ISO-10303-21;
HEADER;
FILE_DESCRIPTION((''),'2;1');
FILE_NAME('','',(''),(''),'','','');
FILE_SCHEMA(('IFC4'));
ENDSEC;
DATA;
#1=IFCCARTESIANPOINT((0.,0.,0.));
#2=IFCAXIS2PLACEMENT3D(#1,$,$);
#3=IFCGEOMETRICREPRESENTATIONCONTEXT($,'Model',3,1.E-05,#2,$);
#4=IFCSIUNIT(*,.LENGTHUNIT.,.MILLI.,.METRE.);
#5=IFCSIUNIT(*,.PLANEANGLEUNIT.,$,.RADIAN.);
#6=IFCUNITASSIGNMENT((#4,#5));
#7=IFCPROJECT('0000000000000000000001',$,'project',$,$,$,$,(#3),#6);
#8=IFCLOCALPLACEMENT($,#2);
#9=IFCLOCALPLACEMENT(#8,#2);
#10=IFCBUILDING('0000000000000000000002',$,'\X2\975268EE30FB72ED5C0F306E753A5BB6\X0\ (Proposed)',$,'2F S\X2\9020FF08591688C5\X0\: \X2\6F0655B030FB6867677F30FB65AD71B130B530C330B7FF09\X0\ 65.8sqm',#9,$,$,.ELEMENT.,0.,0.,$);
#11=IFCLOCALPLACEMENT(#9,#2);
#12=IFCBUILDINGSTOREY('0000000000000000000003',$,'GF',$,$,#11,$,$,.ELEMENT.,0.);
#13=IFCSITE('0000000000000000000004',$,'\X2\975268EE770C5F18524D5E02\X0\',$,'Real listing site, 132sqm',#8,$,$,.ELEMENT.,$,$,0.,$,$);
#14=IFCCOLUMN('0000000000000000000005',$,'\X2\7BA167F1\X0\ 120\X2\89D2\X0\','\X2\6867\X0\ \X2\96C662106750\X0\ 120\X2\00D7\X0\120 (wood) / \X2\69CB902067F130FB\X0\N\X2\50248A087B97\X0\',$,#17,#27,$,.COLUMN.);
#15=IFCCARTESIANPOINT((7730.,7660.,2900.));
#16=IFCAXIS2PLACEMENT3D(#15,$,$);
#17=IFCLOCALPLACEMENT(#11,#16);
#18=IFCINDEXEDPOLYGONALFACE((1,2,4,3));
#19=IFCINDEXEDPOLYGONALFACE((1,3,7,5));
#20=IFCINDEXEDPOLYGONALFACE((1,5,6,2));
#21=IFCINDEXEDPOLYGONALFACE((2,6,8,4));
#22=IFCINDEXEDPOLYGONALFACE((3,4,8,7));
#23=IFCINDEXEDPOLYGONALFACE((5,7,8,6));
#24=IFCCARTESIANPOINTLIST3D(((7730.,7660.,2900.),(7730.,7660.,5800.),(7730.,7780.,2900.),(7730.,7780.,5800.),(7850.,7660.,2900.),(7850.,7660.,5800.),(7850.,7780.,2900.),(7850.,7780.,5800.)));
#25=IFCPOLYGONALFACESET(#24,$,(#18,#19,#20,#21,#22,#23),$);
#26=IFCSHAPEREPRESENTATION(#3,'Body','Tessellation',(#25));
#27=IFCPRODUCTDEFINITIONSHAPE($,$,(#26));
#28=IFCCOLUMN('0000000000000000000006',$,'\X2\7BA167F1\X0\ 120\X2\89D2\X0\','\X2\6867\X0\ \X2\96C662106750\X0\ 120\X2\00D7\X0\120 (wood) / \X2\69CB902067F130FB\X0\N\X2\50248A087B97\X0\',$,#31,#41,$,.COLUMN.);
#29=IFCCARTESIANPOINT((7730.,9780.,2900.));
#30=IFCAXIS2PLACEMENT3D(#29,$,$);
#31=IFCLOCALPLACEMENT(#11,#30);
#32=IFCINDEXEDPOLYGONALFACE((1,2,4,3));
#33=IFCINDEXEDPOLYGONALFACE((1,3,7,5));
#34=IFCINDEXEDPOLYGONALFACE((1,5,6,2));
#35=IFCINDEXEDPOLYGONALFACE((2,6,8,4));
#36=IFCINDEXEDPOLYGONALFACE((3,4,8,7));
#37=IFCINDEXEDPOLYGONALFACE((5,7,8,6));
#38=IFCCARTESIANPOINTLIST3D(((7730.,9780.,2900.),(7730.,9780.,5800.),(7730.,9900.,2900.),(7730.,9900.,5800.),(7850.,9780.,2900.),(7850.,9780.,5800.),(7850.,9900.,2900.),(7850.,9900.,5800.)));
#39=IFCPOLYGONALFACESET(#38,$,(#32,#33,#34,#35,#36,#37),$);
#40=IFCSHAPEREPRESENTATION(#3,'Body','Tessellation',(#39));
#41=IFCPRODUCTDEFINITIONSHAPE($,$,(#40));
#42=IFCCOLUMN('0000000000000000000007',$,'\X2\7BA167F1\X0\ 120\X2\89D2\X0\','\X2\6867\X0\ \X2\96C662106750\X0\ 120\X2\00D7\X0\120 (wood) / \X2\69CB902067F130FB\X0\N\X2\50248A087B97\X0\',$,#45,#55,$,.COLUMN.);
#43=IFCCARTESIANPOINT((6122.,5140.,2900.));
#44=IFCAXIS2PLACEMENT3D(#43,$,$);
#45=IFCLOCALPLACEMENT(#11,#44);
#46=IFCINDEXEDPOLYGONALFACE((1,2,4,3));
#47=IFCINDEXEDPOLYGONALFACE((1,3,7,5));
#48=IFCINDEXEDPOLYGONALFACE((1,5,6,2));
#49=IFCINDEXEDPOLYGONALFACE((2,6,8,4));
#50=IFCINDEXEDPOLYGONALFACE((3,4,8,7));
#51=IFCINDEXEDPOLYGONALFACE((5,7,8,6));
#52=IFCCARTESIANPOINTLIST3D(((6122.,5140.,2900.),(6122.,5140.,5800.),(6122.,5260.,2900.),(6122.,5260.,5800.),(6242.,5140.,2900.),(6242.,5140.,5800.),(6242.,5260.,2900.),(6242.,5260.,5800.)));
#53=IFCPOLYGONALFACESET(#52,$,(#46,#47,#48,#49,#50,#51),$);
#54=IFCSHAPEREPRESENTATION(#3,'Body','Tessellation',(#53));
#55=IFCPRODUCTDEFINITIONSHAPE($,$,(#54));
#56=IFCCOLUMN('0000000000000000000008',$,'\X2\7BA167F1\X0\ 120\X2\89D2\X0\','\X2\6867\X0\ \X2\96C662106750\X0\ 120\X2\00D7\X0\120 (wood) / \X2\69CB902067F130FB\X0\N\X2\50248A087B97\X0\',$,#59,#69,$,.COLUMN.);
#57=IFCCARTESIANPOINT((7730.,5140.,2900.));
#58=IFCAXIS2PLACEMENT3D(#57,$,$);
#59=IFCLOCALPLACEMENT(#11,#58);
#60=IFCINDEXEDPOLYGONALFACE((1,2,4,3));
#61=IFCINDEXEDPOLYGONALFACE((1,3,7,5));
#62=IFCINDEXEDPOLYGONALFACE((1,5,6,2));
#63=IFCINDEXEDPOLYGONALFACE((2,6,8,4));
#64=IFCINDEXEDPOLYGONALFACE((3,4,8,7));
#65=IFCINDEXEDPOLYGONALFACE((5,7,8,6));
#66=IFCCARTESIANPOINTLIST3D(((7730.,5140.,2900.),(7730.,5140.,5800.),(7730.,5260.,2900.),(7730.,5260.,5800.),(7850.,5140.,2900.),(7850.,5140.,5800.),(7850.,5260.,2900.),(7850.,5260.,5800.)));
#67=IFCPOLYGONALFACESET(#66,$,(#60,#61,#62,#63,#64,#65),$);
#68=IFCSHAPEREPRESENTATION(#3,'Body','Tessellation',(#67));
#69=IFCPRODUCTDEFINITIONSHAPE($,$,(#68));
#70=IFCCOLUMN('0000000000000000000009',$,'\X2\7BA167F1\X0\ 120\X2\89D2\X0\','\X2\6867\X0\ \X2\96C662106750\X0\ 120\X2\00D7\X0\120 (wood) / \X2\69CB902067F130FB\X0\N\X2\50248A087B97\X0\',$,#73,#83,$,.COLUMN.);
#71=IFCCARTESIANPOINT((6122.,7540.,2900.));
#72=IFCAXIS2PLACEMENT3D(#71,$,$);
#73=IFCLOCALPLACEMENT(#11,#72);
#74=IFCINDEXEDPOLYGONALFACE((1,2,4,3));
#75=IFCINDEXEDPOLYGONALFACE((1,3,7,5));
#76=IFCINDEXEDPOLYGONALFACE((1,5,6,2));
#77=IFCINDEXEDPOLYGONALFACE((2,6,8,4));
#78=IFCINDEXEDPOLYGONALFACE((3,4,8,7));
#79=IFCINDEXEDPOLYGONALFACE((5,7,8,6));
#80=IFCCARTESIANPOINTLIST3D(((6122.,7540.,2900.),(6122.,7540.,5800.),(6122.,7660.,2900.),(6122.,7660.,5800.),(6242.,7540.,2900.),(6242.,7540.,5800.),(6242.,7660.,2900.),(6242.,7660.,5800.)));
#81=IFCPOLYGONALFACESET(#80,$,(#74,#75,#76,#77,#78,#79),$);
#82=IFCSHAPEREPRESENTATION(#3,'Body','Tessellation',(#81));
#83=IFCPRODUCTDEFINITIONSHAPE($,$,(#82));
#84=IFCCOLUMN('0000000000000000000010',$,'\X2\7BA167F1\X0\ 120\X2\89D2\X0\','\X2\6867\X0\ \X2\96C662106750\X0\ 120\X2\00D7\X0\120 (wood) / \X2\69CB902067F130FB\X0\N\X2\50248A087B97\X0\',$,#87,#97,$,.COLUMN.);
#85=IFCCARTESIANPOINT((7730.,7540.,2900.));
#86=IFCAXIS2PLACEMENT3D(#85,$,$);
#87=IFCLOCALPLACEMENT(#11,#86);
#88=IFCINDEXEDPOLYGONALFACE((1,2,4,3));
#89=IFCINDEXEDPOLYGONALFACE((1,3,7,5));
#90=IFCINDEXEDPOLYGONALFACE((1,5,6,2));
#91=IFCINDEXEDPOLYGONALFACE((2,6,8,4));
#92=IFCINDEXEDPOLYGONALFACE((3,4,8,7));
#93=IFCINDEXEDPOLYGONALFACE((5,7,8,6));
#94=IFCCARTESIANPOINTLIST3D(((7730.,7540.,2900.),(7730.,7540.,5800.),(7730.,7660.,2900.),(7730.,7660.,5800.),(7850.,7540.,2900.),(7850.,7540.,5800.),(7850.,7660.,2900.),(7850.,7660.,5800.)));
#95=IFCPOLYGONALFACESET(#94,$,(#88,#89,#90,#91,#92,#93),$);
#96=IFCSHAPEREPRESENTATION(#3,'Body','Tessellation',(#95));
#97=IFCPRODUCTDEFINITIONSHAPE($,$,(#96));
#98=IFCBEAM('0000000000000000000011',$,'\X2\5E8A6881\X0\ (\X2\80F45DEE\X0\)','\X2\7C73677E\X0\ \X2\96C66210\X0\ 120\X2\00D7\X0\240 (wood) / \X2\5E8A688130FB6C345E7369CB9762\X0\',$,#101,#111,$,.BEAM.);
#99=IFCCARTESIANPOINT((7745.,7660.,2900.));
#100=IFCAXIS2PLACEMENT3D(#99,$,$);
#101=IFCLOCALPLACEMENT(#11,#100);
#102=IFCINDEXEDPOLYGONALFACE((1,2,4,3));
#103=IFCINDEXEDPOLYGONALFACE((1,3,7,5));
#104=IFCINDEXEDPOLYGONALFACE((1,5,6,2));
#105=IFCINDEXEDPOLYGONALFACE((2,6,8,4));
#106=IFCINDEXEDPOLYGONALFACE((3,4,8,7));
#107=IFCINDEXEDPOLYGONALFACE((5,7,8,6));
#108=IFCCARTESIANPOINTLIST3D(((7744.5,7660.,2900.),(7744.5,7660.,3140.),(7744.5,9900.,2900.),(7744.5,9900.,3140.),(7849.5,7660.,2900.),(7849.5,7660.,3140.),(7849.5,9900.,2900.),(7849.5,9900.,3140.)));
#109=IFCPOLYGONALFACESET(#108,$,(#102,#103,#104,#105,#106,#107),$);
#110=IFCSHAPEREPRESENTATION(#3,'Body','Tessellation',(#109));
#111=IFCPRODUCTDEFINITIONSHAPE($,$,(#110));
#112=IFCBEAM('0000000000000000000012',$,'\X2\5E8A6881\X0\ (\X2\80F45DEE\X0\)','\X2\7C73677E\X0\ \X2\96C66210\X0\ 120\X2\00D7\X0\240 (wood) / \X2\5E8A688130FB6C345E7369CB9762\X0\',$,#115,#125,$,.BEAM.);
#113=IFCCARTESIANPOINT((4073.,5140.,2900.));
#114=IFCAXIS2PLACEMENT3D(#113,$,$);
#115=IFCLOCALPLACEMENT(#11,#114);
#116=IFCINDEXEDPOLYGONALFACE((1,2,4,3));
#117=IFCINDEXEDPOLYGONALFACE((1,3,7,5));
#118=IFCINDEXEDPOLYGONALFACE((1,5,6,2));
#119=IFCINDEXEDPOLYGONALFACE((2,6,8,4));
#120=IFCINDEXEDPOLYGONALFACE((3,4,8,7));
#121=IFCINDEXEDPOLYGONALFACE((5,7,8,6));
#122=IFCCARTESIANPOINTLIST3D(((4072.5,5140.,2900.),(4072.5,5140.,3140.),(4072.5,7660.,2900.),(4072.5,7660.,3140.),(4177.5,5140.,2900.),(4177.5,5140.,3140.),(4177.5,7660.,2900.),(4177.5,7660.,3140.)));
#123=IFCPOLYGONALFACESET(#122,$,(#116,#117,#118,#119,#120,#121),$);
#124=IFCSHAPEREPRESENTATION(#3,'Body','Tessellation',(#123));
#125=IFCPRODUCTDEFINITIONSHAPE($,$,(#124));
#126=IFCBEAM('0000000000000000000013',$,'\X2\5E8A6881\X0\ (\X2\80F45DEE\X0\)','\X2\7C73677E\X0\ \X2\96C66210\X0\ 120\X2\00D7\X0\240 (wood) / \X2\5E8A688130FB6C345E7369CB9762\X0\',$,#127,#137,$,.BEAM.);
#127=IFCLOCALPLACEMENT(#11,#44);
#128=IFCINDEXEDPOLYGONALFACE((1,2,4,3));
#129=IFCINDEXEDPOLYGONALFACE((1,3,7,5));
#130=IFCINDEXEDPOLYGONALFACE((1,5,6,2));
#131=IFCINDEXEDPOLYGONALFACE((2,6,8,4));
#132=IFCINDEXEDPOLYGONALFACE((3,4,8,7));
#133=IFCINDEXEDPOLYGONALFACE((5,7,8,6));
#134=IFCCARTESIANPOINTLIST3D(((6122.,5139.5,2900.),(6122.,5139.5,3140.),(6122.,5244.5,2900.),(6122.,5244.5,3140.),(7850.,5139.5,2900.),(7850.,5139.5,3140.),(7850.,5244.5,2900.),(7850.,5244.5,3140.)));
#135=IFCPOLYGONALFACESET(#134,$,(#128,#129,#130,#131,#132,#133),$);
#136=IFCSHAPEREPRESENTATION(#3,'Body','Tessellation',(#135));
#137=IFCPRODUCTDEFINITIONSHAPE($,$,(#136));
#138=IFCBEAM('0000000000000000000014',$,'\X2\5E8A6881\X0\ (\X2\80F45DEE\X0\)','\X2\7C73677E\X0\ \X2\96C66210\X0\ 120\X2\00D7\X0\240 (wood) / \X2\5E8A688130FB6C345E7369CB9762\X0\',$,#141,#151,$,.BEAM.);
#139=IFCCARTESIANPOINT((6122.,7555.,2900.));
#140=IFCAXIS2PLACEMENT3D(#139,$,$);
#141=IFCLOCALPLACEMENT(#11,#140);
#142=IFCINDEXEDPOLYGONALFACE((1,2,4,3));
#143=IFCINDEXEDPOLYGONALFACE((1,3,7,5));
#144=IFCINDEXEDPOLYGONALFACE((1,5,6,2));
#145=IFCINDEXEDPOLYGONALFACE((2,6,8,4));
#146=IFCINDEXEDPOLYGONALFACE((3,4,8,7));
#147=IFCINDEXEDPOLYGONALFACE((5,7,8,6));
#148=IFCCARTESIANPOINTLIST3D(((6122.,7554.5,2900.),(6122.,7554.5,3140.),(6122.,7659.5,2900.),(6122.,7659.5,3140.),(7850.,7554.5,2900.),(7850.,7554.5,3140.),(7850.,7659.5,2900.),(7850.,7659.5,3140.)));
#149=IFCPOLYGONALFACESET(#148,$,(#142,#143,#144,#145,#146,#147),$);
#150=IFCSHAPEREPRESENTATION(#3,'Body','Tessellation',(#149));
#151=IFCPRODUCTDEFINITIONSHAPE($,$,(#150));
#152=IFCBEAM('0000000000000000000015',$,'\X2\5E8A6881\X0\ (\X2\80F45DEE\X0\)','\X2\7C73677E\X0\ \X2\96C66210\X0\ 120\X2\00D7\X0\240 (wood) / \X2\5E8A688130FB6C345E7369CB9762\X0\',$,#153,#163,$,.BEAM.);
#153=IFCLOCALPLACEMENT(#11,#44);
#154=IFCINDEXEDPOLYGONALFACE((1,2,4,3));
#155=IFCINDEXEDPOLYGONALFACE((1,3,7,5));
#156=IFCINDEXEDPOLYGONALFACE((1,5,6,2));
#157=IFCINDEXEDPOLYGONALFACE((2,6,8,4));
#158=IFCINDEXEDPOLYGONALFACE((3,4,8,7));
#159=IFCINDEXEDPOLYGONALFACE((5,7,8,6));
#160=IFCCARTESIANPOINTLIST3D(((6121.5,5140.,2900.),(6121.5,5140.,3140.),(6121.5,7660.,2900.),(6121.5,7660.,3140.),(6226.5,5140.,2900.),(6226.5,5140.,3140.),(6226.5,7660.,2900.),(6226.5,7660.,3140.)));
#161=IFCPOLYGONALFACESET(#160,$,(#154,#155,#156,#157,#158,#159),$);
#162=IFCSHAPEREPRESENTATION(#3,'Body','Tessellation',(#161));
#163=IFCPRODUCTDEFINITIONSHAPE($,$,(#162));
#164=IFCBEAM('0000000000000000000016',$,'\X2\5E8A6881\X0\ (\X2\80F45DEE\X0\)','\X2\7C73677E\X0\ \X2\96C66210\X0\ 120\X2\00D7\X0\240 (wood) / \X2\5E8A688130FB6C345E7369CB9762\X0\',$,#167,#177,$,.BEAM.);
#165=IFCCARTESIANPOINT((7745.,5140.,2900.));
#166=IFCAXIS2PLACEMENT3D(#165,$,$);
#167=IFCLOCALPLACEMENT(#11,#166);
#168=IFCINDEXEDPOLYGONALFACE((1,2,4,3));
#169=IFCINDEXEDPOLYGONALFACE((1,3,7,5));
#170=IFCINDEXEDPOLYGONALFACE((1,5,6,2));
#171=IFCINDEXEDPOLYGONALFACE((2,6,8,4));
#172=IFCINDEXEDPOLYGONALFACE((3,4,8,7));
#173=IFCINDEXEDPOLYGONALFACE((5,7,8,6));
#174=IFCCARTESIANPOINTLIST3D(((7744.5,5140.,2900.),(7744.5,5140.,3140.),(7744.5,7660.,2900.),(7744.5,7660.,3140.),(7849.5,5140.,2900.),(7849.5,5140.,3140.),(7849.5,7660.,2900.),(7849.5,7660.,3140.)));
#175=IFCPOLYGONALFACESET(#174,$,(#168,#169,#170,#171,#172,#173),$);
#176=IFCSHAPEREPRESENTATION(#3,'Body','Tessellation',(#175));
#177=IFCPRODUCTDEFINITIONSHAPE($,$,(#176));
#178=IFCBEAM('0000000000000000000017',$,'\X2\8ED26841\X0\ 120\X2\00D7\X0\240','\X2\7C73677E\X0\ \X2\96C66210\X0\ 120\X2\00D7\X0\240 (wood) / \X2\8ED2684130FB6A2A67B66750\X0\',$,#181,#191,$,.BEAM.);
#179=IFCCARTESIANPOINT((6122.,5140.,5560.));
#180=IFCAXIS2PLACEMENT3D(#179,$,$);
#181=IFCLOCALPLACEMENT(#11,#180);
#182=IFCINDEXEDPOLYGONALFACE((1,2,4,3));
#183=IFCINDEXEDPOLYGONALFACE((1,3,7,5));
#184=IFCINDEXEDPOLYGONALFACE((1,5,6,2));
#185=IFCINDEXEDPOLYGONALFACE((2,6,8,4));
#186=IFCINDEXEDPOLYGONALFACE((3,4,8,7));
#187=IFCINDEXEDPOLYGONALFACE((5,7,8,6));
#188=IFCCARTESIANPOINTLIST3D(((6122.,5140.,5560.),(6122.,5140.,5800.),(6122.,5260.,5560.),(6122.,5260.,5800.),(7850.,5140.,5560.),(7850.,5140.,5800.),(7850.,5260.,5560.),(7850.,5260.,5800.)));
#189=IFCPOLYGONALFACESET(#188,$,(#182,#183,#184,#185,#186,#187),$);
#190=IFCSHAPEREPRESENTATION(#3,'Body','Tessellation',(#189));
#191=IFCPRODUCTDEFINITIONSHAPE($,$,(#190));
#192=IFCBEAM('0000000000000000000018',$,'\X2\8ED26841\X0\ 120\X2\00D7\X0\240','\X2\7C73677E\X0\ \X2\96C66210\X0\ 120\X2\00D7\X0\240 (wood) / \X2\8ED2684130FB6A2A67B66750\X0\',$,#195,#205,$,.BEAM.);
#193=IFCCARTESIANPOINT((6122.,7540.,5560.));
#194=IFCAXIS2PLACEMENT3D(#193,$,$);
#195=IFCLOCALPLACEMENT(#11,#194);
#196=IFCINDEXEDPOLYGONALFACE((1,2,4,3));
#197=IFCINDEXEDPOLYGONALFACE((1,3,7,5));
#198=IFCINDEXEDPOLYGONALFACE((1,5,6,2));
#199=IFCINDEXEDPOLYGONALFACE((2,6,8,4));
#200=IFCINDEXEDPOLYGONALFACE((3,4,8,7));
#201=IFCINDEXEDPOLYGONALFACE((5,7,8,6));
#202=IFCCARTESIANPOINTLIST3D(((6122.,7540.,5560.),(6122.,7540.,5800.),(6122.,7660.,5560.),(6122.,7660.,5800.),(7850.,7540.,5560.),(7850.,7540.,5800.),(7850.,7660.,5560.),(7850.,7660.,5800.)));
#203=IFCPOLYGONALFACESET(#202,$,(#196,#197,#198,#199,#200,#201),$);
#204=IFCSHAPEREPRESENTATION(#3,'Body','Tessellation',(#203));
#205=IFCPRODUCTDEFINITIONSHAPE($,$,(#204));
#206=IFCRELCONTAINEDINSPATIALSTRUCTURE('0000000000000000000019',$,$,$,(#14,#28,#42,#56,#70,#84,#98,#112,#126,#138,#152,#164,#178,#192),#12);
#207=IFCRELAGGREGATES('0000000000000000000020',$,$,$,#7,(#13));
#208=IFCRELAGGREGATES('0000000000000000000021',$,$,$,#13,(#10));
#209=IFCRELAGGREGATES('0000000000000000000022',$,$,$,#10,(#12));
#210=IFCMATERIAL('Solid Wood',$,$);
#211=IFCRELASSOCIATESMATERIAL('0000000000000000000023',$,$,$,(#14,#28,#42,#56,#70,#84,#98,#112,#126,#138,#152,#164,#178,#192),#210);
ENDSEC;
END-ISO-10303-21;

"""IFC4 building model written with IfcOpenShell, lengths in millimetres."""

from ifc_helpers import new_model, si_unit, frame, frame_2d, origin, place, context, project, spatial, rectangle, extrude, material, element, save


model = new_model("IFC4")

# Units and contexts
model_context = context("Model", 3, precision=1e-05, world=origin())
ifc_project = project(units=[si_unit("LENGTHUNIT", "METRE", prefix="MILLI"), si_unit("PLANEANGLEUNIT", "RADIAN")], contexts=[model_context])

# Site, building, storey
site_placement = place(None, origin())
site = spatial("IfcSite", under=ifc_project, at=site_placement, Name="青森県弘前市", ObjectType="Real listing site, 132sqm", CompositionType="ELEMENT", RefElevation=0.0)
building_placement = place(site_placement, origin())
building = spatial("IfcBuilding", under=site, at=building_placement, Name="青森・狭小の町家 (Proposed)", ObjectType="2F S造（外装: 漆喰・桧板・断熱サッシ） 65.8sqm", CompositionType="ELEMENT", ElevationOfRefHeight=0.0, ElevationOfTerrain=0.0)
storey_placement = place(building_placement, origin())
storey = spatial("IfcBuildingStorey", under=building, at=storey_placement, Name="GF", CompositionType="ELEMENT", Elevation=0.0)

# Columns
ifc_material_1 = material(Name="Solid Wood")
column_1_placement = place(storey_placement, frame((7730.0, 7660.0, 2900.0)))
element("IfcColumn", 1, at=column_1_placement, inside=storey, material=ifc_material_1, Name="管柱 120角", Description="桧 集成材 120×120 (wood) / 構造柱・N値計算", PredefinedType="COLUMN", context=model_context, shape_type="SweptSolid", body=[
    extrude(rectangle(XDim=120.0, YDim=120.0, at=frame_2d((60.0, 60.0))), frame((7730.0, 7660.0, 2900.0)), (0.0, 0.0, 1.0), 2900.0),
])
column_2_placement = place(storey_placement, frame((7730.0, 9780.0, 2900.0)))
element("IfcColumn", 2, at=column_2_placement, inside=storey, material=ifc_material_1, Name="管柱 120角", Description="桧 集成材 120×120 (wood) / 構造柱・N値計算", PredefinedType="COLUMN", context=model_context, shape_type="SweptSolid", body=[
    extrude(rectangle(XDim=120.0, YDim=120.0, at=frame_2d((60.0, 60.0))), frame((7730.0, 9780.0, 2900.0)), (0.0, 0.0, 1.0), 2900.0),
])
column_3_placement = place(storey_placement, frame((6122.0, 5140.0, 2900.0)))
element("IfcColumn", 3, at=column_3_placement, inside=storey, material=ifc_material_1, Name="管柱 120角", Description="桧 集成材 120×120 (wood) / 構造柱・N値計算", PredefinedType="COLUMN", context=model_context, shape_type="SweptSolid", body=[
    extrude(rectangle(XDim=120.0, YDim=120.0, at=frame_2d((60.0, 60.0))), frame((6122.0, 5140.0, 2900.0)), (0.0, 0.0, 1.0), 2900.0),
])
column_4_placement = place(storey_placement, frame((7730.0, 5140.0, 2900.0)))
element("IfcColumn", 4, at=column_4_placement, inside=storey, material=ifc_material_1, Name="管柱 120角", Description="桧 集成材 120×120 (wood) / 構造柱・N値計算", PredefinedType="COLUMN", context=model_context, shape_type="SweptSolid", body=[
    extrude(rectangle(XDim=120.0, YDim=120.0, at=frame_2d((60.0, 60.0))), frame((7730.0, 5140.0, 2900.0)), (0.0, 0.0, 1.0), 2900.0),
])
column_5_placement = place(storey_placement, frame((6122.0, 7540.0, 2900.0)))
element("IfcColumn", 5, at=column_5_placement, inside=storey, material=ifc_material_1, Name="管柱 120角", Description="桧 集成材 120×120 (wood) / 構造柱・N値計算", PredefinedType="COLUMN", context=model_context, shape_type="SweptSolid", body=[
    extrude(rectangle(XDim=120.0, YDim=120.0, at=frame_2d((60.0, 60.0))), frame((6122.0, 7540.0, 2900.0)), (0.0, 0.0, 1.0), 2900.0),
])
column_6_placement = place(storey_placement, frame((7730.0, 7540.0, 2900.0)))
element("IfcColumn", 6, at=column_6_placement, inside=storey, material=ifc_material_1, Name="管柱 120角", Description="桧 集成材 120×120 (wood) / 構造柱・N値計算", PredefinedType="COLUMN", context=model_context, shape_type="SweptSolid", body=[
    extrude(rectangle(XDim=120.0, YDim=120.0, at=frame_2d((60.0, 60.0))), frame((7730.0, 7540.0, 2900.0)), (0.0, 0.0, 1.0), 2900.0),
])

# Beams
beam_1_placement = place(storey_placement, frame((7745.0, 7660.0, 2900.0)))
element("IfcBeam", 7, at=beam_1_placement, inside=storey, material=ifc_material_1, Name="床梁 (胴差)", Description="米松 集成 120×240 (wood) / 床梁・水平構面", PredefinedType="BEAM", context=model_context, shape_type="SweptSolid", body=[
    extrude(rectangle(XDim=105.0, YDim=2240.0, at=frame_2d((52.0, 1120.0))), frame((7745.0, 7660.0, 2900.0)), (0.0, 0.0, 1.0), 240.0),
])
beam_2_placement = place(storey_placement, frame((4073.0, 5140.0, 2900.0)))
element("IfcBeam", 8, at=beam_2_placement, inside=storey, material=ifc_material_1, Name="床梁 (胴差)", Description="米松 集成 120×240 (wood) / 床梁・水平構面", PredefinedType="BEAM", context=model_context, shape_type="SweptSolid", body=[
    extrude(rectangle(XDim=105.0, YDim=2520.0, at=frame_2d((52.0, 1260.0))), frame((4073.0, 5140.0, 2900.0)), (0.0, 0.0, 1.0), 240.0),
])
beam_3_placement = place(storey_placement, frame((6122.0, 5140.0, 2900.0)))
element("IfcBeam", 9, at=beam_3_placement, inside=storey, material=ifc_material_1, Name="床梁 (胴差)", Description="米松 集成 120×240 (wood) / 床梁・水平構面", PredefinedType="BEAM", context=model_context, shape_type="SweptSolid", body=[
    extrude(rectangle(XDim=1728.0, YDim=105.0, at=frame_2d((864.0, 52.0))), frame((6122.0, 5140.0, 2900.0)), (0.0, 0.0, 1.0), 240.0),
])
beam_4_placement = place(storey_placement, frame((6122.0, 7555.0, 2900.0)))
element("IfcBeam", 10, at=beam_4_placement, inside=storey, material=ifc_material_1, Name="床梁 (胴差)", Description="米松 集成 120×240 (wood) / 床梁・水平構面", PredefinedType="BEAM", context=model_context, shape_type="SweptSolid", body=[
    extrude(rectangle(XDim=1728.0, YDim=105.0, at=frame_2d((864.0, 52.0))), frame((6122.0, 7555.0, 2900.0)), (0.0, 0.0, 1.0), 240.0),
])
beam_5_placement = place(storey_placement, frame((6122.0, 5140.0, 2900.0)))
element("IfcBeam", 11, at=beam_5_placement, inside=storey, material=ifc_material_1, Name="床梁 (胴差)", Description="米松 集成 120×240 (wood) / 床梁・水平構面", PredefinedType="BEAM", context=model_context, shape_type="SweptSolid", body=[
    extrude(rectangle(XDim=105.0, YDim=2520.0, at=frame_2d((52.0, 1260.0))), frame((6122.0, 5140.0, 2900.0)), (0.0, 0.0, 1.0), 240.0),
])
beam_6_placement = place(storey_placement, frame((7745.0, 5140.0, 2900.0)))
element("IfcBeam", 12, at=beam_6_placement, inside=storey, material=ifc_material_1, Name="床梁 (胴差)", Description="米松 集成 120×240 (wood) / 床梁・水平構面", PredefinedType="BEAM", context=model_context, shape_type="SweptSolid", body=[
    extrude(rectangle(XDim=105.0, YDim=2520.0, at=frame_2d((52.0, 1260.0))), frame((7745.0, 5140.0, 2900.0)), (0.0, 0.0, 1.0), 240.0),
])
beam_7_placement = place(storey_placement, frame((6122.0, 5140.0, 5560.0)))
element("IfcBeam", 13, at=beam_7_placement, inside=storey, material=ifc_material_1, Name="軒桁 120×240", Description="米松 集成 120×240 (wood) / 軒桁・横架材", PredefinedType="BEAM", context=model_context, shape_type="SweptSolid", body=[
    extrude(rectangle(XDim=1728.0, YDim=120.0, at=frame_2d((864.0, 60.0))), frame((6122.0, 5140.0, 5560.0)), (0.0, 0.0, 1.0), 240.0),
])
beam_8_placement = place(storey_placement, frame((6122.0, 7540.0, 5560.0)))
element("IfcBeam", 14, at=beam_8_placement, inside=storey, material=ifc_material_1, Name="軒桁 120×240", Description="米松 集成 120×240 (wood) / 軒桁・横架材", PredefinedType="BEAM", context=model_context, shape_type="SweptSolid", body=[
    extrude(rectangle(XDim=1728.0, YDim=120.0, at=frame_2d((864.0, 60.0))), frame((6122.0, 7540.0, 5560.0)), (0.0, 0.0, 1.0), 240.0),
])

save(model, "model.ifc")
